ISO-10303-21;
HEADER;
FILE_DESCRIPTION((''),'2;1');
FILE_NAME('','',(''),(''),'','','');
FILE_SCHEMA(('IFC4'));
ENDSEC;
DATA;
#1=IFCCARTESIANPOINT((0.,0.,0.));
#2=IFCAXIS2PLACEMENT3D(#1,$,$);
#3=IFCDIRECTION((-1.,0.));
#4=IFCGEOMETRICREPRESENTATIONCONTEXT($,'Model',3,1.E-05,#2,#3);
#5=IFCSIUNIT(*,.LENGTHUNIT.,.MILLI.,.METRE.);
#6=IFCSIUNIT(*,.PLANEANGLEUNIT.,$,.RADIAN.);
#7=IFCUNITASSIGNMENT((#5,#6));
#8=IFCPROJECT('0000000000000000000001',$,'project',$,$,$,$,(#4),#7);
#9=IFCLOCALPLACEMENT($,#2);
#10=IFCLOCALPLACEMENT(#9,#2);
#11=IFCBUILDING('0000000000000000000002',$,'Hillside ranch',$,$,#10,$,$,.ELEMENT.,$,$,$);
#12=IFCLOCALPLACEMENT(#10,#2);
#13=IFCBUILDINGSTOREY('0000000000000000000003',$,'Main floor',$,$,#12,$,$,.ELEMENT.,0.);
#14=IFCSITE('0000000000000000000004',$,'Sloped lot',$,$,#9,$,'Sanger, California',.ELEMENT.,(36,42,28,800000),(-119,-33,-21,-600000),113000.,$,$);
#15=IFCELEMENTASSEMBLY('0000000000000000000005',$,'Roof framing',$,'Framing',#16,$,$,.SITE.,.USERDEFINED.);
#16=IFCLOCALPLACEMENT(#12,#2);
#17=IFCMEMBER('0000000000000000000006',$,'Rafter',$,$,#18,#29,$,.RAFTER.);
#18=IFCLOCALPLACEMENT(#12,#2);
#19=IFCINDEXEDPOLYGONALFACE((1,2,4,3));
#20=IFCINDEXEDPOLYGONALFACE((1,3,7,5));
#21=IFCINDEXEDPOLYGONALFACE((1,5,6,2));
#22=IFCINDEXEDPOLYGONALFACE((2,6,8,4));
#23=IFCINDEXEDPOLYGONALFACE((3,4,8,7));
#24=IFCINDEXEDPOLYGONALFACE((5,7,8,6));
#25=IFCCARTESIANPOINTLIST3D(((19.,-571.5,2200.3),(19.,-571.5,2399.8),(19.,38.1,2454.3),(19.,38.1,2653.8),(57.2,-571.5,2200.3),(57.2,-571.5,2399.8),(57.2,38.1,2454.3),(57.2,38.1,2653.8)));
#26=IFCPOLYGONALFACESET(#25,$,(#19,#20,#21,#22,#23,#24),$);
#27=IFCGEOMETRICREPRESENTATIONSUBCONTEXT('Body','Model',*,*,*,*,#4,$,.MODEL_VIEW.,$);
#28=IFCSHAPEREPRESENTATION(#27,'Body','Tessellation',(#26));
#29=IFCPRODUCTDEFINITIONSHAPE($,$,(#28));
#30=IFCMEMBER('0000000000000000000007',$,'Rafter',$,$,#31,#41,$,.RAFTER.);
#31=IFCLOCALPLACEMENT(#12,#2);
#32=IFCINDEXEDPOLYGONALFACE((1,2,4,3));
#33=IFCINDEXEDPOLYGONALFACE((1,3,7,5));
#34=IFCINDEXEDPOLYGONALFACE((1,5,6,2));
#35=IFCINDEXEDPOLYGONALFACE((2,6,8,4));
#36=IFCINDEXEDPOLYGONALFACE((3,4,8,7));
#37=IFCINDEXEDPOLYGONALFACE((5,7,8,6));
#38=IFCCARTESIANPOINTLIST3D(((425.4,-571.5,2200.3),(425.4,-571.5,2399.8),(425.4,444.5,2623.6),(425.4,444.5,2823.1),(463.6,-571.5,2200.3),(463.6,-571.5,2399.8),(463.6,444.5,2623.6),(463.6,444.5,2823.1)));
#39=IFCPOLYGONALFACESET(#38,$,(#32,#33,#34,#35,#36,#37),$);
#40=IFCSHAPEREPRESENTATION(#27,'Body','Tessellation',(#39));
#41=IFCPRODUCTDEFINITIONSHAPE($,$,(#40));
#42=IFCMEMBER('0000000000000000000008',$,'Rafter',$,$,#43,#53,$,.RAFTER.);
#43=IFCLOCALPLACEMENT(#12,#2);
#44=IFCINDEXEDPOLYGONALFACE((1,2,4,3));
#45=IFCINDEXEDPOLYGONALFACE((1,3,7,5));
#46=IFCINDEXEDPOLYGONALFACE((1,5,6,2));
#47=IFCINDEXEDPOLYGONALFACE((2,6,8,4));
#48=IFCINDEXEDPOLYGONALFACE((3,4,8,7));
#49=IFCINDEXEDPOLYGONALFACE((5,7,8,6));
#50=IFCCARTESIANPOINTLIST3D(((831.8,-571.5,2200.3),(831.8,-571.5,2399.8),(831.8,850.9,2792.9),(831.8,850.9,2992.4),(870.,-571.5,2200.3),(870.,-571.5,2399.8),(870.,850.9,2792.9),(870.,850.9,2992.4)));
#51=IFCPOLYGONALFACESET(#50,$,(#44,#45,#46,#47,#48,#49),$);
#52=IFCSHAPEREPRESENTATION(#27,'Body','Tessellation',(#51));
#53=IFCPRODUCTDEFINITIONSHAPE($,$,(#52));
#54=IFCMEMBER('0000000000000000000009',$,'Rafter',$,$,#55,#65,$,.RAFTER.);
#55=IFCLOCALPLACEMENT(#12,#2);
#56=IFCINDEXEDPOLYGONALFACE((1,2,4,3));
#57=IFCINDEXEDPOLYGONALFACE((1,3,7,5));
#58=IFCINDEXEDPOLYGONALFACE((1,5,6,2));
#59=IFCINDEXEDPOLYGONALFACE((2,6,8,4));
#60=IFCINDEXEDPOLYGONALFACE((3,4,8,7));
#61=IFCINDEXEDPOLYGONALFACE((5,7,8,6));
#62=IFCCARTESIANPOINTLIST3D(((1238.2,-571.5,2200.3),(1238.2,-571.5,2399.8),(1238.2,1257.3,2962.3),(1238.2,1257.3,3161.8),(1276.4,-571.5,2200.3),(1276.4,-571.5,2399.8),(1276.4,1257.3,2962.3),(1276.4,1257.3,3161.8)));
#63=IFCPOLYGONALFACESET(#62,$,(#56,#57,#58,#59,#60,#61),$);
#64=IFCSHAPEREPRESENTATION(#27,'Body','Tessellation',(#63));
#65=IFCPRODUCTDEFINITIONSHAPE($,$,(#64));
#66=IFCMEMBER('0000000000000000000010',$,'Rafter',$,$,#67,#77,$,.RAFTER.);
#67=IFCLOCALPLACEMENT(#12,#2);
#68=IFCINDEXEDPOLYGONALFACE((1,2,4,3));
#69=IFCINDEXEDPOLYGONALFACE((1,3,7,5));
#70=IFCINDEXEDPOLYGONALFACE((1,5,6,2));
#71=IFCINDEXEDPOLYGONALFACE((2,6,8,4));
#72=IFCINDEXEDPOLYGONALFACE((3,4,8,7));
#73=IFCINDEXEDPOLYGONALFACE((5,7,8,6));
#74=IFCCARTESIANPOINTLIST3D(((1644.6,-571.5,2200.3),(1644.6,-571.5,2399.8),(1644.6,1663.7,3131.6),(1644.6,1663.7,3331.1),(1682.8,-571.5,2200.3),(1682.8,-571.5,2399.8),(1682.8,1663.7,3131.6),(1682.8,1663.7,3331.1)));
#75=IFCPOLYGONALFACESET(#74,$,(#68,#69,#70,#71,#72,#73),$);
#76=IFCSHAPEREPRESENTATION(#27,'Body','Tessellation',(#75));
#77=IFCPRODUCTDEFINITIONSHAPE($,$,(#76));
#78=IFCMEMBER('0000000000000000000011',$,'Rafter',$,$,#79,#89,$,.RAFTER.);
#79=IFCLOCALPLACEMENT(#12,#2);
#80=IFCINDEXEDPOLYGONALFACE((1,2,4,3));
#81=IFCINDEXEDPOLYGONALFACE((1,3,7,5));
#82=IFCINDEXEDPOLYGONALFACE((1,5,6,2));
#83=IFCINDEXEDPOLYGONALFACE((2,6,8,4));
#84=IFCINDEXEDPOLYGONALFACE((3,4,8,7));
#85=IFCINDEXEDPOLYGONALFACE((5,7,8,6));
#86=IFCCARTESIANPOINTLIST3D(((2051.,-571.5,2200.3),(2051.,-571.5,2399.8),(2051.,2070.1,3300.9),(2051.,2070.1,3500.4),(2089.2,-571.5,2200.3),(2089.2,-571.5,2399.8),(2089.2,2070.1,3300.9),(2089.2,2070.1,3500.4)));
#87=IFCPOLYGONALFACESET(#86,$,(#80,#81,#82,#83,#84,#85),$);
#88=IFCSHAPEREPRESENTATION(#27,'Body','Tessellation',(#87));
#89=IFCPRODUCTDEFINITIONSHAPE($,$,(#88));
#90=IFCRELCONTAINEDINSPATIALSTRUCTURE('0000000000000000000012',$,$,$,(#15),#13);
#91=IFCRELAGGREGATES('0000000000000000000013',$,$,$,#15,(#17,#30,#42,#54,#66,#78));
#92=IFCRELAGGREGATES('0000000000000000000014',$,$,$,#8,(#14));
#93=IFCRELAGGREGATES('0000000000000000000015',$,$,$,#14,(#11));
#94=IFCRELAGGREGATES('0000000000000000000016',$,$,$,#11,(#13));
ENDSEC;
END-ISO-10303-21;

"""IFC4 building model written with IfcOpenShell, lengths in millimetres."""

from ifc_helpers import new_model, si_unit, direction, frame, origin, origin_with_axes, place, context, subcontext, project, spatial, polyline, outline, extrude, element, aggregate, save


model = new_model("IFC4")

# Units and contexts
model_context = context("Model", 3, precision=1e-05, world=origin(), true_north=direction((-1.0, 0.0)))
body_context = subcontext(model_context, "Body", "Model", "MODEL_VIEW")
ifc_project = project(units=[si_unit("LENGTHUNIT", "METRE", prefix="MILLI"), si_unit("PLANEANGLEUNIT", "RADIAN")], contexts=[model_context])

# Site, building, storey
site_placement = place(None, origin())
site = spatial("IfcSite", under=ifc_project, at=site_placement, Name="Sloped lot", LongName="Sanger, California", CompositionType="ELEMENT", RefLatitude=(36, 42, 28, 800000), RefLongitude=(-119, -33, -21, -600000), RefElevation=113000.0)
building_placement = place(site_placement, origin())
building = spatial("IfcBuilding", under=site, at=building_placement, Name="Hillside ranch", CompositionType="ELEMENT")
storey_placement = place(building_placement, origin())
storey = spatial("IfcBuildingStorey", under=building, at=storey_placement, Name="Main floor", CompositionType="ELEMENT", Elevation=0.0)

# Element assembly, members
assembly_placement = place(storey_placement, origin_with_axes())
assembly = element("IfcElementAssembly", 1, at=assembly_placement, inside=storey, Name="Roof framing", ObjectType="Framing", AssemblyPlace="SITE", PredefinedType="USERDEFINED")
member_1_placement = place(storey_placement, origin_with_axes())
member_1 = element("IfcMember", 2, at=member_1_placement, Name="Rafter", PredefinedType="RAFTER", context=body_context, shape_type="SweptSolid", body=[
    extrude(outline(polyline([(0.0, 0.0), (38.1, 0.0), (38.1, 199.5), (0.0, 199.5), (0.0, 0.0)])), frame((57.1, -571.5, 2200.3), z_axis=(0.0, 1.0, 0.0), x_axis=(-1.0, 0.0, 0.0)), (0.0, 0.384615, 0.923077), 660.4),
])
member_2_placement = place(storey_placement, origin_with_axes())
member_2 = element("IfcMember", 3, at=member_2_placement, Name="Rafter", PredefinedType="RAFTER", context=body_context, shape_type="SweptSolid", body=[
    extrude(outline(polyline([(0.0, 0.0), (38.1, 0.0), (38.1, 199.5), (0.0, 199.5), (0.0, 0.0)])), frame((463.6, -571.5, 2200.3), z_axis=(0.0, 1.0, 0.0), x_axis=(-1.0, 0.0, 0.0)), (0.0, 0.384615, 0.923077), 1100.7),
])
member_3_placement = place(storey_placement, origin_with_axes())
member_3 = element("IfcMember", 4, at=member_3_placement, Name="Rafter", PredefinedType="RAFTER", context=body_context, shape_type="SweptSolid", body=[
    extrude(outline(polyline([(0.0, 0.0), (38.1, 0.0), (38.1, 199.5), (0.0, 199.5), (0.0, 0.0)])), frame((870.0, -571.5, 2200.3), z_axis=(0.0, 1.0, 0.0), x_axis=(-1.0, 0.0, 0.0)), (0.0, 0.384615, 0.923077), 1540.9),
])
member_4_placement = place(storey_placement, origin_with_axes())
member_4 = element("IfcMember", 5, at=member_4_placement, Name="Rafter", PredefinedType="RAFTER", context=body_context, shape_type="SweptSolid", body=[
    extrude(outline(polyline([(0.0, 0.0), (38.1, 0.0), (38.1, 199.5), (0.0, 199.5), (0.0, 0.0)])), frame((1276.3, -571.5, 2200.3), z_axis=(0.0, 1.0, 0.0), x_axis=(-1.0, 0.0, 0.0)), (0.0, 0.384615, 0.923077), 1981.2),
])
member_5_placement = place(storey_placement, origin_with_axes())
member_5 = element("IfcMember", 6, at=member_5_placement, Name="Rafter", PredefinedType="RAFTER", context=body_context, shape_type="SweptSolid", body=[
    extrude(outline(polyline([(0.0, 0.0), (38.1, 0.0), (38.1, 199.5), (0.0, 199.5), (0.0, 0.0)])), frame((1682.8, -571.5, 2200.3), z_axis=(0.0, 1.0, 0.0), x_axis=(-1.0, 0.0, 0.0)), (0.0, 0.384615, 0.923077), 2421.5),
])
member_6_placement = place(storey_placement, origin_with_axes())
member_6 = element("IfcMember", 7, at=member_6_placement, Name="Rafter", PredefinedType="RAFTER", context=body_context, shape_type="SweptSolid", body=[
    extrude(outline(polyline([(0.0, 0.0), (38.1, 0.0), (38.1, 199.5), (0.0, 199.5), (0.0, 0.0)])), frame((2089.2, -571.5, 2200.3), z_axis=(0.0, 1.0, 0.0), x_axis=(-1.0, 0.0, 0.0)), (0.0, 0.384615, 0.923077), 2861.7),
])
aggregate(assembly, [member_1, member_2, member_3, member_4, member_5, member_6])

save(model, "model.ifc")
